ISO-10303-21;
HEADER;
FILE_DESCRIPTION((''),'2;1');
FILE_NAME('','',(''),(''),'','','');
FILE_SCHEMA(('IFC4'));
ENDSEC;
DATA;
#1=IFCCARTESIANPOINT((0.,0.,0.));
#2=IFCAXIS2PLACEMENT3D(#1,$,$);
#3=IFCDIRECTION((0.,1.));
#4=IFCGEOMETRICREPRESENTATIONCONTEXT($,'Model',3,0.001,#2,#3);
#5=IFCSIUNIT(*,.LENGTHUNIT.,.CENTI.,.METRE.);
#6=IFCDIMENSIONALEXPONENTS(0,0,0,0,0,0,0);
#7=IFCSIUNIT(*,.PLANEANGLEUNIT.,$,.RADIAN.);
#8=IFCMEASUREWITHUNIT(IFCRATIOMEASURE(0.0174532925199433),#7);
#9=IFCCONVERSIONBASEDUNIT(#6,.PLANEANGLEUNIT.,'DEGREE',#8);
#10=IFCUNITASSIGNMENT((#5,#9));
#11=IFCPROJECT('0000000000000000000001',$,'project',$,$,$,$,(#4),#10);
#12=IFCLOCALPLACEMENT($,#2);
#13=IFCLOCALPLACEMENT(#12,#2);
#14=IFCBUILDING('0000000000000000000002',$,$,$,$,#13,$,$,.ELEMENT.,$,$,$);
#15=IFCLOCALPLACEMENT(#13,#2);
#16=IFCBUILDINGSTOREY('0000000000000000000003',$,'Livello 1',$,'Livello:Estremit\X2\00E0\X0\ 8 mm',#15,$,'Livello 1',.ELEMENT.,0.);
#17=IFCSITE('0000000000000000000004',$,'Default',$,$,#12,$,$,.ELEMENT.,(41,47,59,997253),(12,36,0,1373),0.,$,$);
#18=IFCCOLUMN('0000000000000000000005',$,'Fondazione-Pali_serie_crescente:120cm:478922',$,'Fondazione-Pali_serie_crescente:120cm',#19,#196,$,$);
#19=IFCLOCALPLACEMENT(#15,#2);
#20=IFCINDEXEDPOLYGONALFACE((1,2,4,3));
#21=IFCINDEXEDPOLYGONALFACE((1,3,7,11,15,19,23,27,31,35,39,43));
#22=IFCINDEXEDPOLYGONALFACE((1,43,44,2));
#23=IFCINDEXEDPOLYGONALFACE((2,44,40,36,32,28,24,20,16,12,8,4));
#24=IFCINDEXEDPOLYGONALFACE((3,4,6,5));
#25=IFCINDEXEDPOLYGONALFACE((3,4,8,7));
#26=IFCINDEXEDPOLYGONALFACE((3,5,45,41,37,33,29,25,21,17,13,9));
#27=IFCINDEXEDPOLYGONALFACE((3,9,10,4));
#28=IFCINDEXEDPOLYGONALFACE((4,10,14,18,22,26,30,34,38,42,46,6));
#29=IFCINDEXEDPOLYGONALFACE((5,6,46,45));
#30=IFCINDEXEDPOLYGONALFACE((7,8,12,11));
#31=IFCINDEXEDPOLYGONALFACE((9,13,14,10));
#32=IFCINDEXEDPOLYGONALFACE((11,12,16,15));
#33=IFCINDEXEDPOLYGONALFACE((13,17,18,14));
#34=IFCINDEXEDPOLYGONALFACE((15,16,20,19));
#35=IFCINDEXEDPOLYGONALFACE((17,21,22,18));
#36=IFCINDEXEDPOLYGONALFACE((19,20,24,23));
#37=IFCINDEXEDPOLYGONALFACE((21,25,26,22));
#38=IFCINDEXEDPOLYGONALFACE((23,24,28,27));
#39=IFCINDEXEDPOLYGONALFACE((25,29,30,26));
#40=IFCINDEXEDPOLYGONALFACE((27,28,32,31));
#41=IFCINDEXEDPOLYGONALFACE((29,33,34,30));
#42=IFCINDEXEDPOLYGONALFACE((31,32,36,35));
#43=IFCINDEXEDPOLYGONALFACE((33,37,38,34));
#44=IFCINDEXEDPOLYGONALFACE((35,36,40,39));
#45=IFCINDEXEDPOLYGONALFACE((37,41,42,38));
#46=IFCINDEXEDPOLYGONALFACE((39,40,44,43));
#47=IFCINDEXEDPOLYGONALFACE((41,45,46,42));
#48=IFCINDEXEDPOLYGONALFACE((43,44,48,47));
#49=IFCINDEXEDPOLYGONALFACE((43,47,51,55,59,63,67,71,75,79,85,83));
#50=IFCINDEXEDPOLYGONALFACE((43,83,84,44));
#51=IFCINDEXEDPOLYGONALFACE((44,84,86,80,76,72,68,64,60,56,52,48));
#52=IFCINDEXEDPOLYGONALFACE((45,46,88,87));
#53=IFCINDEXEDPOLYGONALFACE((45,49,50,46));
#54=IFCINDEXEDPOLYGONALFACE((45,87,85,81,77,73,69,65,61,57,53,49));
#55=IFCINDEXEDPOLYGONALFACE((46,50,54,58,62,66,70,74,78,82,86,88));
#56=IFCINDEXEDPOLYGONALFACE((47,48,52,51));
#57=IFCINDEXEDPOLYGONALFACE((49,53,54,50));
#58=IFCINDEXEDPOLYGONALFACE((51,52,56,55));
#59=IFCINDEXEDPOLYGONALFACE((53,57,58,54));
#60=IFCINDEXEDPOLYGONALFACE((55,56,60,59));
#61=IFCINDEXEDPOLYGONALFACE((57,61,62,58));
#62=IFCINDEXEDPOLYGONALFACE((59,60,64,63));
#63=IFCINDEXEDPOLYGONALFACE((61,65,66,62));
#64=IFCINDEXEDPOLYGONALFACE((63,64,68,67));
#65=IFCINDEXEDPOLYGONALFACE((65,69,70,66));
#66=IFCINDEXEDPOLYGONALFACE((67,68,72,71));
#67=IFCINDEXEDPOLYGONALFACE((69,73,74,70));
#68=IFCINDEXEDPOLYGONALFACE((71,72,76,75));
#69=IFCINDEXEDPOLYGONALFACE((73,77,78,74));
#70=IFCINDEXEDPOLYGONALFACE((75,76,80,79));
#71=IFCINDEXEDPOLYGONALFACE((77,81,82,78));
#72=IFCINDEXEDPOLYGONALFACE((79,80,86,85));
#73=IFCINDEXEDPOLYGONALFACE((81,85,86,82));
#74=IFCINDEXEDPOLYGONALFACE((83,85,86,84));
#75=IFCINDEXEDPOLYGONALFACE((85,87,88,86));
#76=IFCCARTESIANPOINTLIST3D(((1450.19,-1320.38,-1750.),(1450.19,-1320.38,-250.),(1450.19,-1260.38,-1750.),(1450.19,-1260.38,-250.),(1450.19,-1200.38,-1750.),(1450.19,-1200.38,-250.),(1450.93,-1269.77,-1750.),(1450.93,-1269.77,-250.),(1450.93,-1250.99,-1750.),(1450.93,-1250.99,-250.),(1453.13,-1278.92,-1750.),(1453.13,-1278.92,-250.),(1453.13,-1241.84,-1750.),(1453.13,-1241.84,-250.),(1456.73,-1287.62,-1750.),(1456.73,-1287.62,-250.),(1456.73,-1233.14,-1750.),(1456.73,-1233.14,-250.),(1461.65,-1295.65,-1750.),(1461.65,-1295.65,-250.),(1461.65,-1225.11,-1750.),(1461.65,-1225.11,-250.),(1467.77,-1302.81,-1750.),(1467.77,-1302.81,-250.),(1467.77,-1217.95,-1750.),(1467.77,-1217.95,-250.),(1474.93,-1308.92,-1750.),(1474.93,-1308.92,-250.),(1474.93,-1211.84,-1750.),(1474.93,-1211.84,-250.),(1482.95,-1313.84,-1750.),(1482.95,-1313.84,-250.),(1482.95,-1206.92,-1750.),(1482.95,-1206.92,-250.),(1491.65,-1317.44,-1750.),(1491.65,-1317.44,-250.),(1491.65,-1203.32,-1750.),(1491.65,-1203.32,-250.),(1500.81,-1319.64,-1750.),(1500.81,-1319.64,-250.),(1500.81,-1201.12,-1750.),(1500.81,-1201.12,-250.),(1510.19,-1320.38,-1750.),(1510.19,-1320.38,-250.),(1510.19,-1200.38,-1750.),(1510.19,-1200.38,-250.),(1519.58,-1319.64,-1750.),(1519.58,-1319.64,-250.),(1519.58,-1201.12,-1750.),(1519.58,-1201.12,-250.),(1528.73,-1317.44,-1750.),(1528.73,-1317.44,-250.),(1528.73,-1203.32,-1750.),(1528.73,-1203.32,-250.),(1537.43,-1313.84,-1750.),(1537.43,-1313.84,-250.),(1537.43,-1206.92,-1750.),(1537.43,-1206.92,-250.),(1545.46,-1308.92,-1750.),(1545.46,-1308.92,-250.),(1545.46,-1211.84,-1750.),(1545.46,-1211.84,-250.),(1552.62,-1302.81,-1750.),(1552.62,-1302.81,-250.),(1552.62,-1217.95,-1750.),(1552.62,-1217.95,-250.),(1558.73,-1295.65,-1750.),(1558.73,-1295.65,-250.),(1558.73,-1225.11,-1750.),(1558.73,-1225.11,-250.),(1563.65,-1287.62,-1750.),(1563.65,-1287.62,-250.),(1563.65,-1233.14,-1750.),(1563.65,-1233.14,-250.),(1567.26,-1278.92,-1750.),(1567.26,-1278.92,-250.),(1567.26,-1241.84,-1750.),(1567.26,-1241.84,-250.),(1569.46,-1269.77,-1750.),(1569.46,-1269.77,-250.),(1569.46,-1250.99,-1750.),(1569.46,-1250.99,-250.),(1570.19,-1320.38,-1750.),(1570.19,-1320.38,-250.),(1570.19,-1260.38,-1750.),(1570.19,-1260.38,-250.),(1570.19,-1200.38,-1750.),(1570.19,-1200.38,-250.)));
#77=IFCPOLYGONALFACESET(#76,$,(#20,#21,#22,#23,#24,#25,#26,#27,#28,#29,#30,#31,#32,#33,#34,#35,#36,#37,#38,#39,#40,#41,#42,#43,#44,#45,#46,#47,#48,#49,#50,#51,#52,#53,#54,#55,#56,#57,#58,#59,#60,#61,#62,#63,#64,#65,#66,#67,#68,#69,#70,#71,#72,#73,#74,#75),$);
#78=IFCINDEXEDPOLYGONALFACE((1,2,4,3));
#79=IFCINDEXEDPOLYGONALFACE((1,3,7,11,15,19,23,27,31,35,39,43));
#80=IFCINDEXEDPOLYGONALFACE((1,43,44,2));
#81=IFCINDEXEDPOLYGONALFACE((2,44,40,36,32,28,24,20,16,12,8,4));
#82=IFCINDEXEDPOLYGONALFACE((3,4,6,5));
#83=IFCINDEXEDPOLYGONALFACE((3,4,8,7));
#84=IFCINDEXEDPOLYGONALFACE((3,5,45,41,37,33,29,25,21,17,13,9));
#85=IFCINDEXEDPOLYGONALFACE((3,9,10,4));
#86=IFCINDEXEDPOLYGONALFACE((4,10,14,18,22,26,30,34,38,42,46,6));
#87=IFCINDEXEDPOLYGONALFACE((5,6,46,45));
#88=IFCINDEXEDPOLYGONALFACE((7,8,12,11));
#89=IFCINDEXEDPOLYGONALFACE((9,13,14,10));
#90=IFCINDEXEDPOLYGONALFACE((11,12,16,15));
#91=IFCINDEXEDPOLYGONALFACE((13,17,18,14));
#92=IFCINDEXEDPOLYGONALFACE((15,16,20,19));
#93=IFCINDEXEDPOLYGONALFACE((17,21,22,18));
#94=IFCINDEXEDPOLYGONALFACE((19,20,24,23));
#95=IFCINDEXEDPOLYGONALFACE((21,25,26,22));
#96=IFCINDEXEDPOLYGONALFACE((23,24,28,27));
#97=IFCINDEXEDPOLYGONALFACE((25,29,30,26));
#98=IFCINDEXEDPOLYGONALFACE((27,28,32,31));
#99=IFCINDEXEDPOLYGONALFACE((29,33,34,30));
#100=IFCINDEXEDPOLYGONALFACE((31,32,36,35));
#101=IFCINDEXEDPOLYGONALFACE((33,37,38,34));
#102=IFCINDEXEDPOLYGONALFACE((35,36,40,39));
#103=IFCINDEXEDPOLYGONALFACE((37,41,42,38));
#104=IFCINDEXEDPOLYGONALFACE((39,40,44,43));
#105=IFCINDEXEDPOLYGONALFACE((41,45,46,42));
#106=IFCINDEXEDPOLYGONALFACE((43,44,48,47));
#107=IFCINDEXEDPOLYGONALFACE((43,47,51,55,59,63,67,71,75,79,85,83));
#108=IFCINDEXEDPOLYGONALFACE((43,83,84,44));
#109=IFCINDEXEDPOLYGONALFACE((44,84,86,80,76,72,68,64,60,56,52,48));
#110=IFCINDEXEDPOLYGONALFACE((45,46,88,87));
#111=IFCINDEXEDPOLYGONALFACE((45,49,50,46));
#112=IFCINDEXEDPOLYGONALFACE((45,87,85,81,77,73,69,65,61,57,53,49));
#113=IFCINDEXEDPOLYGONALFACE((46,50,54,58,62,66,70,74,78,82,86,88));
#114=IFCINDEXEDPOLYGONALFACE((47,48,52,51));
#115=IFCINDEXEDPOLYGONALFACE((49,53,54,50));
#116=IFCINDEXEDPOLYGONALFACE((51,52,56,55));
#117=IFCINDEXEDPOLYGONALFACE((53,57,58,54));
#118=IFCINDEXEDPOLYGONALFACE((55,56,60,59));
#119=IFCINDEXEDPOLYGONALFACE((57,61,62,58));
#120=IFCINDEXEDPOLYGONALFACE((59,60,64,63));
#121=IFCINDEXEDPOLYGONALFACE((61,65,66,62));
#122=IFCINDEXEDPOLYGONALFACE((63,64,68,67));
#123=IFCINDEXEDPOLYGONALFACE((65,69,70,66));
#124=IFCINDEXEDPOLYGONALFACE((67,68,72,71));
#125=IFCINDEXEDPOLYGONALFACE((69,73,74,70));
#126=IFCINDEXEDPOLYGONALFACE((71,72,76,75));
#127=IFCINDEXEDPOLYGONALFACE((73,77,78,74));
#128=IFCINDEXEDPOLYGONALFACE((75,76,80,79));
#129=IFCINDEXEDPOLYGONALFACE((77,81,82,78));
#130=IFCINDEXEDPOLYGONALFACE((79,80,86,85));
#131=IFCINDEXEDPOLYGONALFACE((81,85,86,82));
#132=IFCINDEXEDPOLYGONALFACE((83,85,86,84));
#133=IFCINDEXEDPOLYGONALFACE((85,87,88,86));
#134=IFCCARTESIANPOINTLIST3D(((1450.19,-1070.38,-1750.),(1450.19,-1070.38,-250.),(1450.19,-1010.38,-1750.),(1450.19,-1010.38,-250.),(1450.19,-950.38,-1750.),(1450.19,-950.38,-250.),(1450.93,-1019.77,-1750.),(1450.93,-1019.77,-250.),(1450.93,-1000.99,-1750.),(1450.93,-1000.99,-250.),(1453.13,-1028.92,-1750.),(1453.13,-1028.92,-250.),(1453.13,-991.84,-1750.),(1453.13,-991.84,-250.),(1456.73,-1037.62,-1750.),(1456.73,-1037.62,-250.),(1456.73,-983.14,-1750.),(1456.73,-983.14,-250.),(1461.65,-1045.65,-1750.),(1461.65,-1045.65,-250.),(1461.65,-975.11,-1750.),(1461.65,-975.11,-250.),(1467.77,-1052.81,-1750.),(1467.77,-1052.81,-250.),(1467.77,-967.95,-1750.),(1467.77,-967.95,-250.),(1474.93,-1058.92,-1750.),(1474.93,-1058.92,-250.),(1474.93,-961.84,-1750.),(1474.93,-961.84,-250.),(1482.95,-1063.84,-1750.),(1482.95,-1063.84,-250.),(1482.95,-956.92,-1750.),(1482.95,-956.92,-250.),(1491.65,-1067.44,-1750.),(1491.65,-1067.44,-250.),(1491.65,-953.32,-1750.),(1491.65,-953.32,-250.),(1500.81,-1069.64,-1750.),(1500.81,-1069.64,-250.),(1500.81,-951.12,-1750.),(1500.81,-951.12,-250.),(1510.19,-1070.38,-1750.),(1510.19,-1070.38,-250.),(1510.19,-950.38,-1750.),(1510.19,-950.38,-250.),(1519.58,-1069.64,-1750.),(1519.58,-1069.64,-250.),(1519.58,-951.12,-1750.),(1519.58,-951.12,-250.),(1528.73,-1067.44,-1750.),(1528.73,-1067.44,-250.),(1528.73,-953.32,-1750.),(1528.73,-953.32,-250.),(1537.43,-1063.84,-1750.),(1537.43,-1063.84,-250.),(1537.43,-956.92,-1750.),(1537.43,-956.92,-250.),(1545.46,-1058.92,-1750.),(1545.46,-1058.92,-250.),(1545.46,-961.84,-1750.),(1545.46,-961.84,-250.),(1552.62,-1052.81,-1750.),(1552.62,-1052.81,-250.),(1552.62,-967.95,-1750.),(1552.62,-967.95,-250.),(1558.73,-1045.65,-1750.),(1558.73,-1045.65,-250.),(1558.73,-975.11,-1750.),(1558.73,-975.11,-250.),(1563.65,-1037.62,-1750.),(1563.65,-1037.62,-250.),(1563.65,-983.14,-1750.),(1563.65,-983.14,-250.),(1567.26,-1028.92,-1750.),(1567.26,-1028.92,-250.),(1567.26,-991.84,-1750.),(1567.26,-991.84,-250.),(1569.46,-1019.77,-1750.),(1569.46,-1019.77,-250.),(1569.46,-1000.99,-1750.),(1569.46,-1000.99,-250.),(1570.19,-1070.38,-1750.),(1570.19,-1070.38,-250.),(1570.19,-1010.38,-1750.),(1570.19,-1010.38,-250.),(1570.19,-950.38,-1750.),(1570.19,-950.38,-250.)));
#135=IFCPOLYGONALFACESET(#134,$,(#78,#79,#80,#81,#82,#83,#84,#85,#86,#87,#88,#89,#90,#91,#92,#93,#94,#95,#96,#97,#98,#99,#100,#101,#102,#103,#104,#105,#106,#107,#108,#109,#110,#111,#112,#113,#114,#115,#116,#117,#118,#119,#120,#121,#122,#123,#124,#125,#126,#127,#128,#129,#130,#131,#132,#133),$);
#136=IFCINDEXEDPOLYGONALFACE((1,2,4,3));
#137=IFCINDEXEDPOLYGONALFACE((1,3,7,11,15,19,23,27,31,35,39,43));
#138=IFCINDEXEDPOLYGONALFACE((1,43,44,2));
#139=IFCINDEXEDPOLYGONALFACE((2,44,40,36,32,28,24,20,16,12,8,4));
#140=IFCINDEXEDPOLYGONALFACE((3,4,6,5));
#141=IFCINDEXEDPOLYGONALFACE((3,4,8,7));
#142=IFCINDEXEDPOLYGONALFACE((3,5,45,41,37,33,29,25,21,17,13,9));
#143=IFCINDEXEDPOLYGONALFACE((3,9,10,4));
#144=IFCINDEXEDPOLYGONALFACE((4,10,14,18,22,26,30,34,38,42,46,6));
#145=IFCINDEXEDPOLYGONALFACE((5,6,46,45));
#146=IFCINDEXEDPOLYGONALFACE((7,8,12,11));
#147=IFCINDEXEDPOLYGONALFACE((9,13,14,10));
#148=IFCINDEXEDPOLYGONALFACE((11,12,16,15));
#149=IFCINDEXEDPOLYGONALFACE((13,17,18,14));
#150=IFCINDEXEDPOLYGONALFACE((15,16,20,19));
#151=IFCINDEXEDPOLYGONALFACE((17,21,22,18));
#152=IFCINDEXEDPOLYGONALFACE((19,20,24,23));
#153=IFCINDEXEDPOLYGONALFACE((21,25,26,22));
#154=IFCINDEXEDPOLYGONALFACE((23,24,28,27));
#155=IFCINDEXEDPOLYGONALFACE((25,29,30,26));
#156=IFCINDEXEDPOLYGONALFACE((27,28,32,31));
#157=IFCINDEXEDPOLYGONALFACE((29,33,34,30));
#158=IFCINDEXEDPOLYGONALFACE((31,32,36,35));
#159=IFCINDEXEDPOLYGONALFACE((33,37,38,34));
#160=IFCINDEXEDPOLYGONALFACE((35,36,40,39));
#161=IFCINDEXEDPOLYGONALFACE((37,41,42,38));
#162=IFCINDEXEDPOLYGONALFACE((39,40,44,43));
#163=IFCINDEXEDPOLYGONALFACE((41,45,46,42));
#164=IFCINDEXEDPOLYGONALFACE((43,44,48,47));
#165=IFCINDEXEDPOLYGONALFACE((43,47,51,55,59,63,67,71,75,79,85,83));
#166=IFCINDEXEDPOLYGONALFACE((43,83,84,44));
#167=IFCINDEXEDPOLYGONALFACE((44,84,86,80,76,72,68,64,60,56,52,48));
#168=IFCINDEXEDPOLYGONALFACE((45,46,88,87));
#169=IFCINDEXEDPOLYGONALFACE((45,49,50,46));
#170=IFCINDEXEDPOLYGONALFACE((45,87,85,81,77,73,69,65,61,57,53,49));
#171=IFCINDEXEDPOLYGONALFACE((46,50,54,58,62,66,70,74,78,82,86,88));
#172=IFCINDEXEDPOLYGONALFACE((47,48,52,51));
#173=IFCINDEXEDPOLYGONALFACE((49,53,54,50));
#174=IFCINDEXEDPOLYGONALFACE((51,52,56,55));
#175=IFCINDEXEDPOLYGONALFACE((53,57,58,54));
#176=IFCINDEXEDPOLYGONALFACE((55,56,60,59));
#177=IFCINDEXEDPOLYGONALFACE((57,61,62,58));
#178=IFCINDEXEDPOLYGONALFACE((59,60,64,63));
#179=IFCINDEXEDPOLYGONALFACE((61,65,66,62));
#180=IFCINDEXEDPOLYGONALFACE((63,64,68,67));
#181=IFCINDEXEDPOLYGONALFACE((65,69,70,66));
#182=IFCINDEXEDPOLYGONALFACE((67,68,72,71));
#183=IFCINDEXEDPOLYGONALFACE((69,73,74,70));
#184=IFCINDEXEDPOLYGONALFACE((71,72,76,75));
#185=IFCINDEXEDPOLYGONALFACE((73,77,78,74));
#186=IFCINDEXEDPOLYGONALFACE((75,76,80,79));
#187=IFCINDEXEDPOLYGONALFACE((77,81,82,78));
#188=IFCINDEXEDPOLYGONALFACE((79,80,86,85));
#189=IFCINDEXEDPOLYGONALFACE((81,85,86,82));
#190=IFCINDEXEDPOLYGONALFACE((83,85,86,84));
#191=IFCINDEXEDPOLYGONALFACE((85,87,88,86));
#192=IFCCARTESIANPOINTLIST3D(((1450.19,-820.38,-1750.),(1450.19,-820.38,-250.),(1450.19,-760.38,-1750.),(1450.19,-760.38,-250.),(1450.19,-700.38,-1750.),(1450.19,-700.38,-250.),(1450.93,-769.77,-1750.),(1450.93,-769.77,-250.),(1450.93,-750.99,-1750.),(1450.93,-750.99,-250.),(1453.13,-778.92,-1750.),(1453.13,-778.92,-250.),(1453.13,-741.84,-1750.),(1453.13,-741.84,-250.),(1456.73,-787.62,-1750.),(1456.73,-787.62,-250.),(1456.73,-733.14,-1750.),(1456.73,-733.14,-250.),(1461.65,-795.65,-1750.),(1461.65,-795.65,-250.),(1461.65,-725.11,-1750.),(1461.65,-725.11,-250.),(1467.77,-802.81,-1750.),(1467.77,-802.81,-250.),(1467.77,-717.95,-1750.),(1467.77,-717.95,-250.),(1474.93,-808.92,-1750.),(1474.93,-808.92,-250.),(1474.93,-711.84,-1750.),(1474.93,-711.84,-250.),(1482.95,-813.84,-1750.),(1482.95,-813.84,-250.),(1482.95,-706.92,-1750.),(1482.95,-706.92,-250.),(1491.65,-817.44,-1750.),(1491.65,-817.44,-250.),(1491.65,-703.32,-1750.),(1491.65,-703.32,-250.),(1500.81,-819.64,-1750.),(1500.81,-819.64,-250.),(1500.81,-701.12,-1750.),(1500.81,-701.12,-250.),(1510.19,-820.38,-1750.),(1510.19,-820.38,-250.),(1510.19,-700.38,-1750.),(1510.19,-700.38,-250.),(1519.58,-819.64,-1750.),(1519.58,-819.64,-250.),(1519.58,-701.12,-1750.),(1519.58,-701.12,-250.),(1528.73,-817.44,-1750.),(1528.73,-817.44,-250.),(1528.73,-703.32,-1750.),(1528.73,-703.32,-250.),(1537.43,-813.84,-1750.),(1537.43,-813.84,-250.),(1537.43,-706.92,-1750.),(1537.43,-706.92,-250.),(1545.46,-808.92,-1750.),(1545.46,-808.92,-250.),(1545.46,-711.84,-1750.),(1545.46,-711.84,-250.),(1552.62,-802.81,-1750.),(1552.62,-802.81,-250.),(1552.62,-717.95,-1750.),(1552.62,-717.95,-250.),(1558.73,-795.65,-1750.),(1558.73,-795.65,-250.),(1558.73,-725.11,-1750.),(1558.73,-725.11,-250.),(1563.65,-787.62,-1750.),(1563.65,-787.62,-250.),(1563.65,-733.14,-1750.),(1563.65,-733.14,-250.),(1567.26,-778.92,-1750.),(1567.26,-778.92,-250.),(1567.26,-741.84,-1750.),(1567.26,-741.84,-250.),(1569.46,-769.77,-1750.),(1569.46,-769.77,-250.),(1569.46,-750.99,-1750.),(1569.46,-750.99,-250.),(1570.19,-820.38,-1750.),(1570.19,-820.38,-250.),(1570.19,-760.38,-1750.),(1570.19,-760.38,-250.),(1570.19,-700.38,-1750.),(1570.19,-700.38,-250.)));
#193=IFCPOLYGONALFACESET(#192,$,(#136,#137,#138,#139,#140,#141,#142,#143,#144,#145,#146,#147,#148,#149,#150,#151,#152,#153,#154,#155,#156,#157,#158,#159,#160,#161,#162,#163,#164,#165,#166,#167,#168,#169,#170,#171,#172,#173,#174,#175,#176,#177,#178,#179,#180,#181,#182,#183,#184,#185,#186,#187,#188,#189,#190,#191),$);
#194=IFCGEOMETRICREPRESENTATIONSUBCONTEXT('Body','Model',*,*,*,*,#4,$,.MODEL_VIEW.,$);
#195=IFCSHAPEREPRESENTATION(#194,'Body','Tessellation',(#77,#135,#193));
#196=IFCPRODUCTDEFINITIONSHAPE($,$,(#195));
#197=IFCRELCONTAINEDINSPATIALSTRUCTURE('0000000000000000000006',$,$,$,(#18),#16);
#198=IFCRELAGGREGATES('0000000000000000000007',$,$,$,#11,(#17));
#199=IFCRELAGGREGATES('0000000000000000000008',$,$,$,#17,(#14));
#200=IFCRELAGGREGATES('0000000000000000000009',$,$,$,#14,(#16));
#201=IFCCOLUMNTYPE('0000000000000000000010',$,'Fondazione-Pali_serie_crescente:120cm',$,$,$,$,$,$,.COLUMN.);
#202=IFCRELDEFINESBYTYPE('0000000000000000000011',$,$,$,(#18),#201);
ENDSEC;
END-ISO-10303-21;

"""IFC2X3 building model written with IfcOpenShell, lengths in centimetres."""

from ifc_helpers import new_model, entity, si_unit, converted_unit, direction, frame, frame_2d, origin, origin_2d_with_axis, place, context, subcontext, project, spatial, rectangle, circle, extrude, boolean, source, transform, mapped, type_object, type_shapes, element, save


model = new_model("IFC2X3")

# Units and contexts
model_context = context("Model", 3, precision=0.001, world=origin(), true_north=direction((0.0, 1.0)))
body_context = subcontext(model_context, "Body", "Model", "MODEL_VIEW")
ifc_project = project(units=[si_unit("LENGTHUNIT", "METRE", prefix="CENTI"), converted_unit("PLANEANGLEUNIT", "DEGREE", entity("IfcRatioMeasure", 0.0174532925199433), si_unit("PLANEANGLEUNIT", "RADIAN"), dimensions=[0, 0, 0, 0, 0, 0, 0])], contexts=[model_context])

# Site, building, storey
site_placement = place(None, origin())
site = spatial("IfcSite", under=ifc_project, at=site_placement, Name="Default", CompositionType="ELEMENT", RefLatitude=(41, 47, 59, 997253), RefLongitude=(12, 36, 0, 1373), RefElevation=0.0)
building_placement = place(site_placement, origin())
building = spatial("IfcBuilding", under=site, at=building_placement, CompositionType="ELEMENT")
storey_placement = place(building_placement, origin())
storey = spatial("IfcBuildingStorey", under=building, at=storey_placement, Name="Livello 1", ObjectType="Livello:Estremità 8 mm", LongName="Livello 1", CompositionType="ELEMENT", Elevation=0.0)

# Column
column_type_1 = type_object("IfcColumnType", Name="Fondazione-Pali_serie_crescente:120cm", PredefinedType="COLUMN")
shared_shape_1 = source(origin(), body_context, "Body", "SweptSolid", [
    boolean("DIFFERENCE", extrude(rectangle(XDim=1500.0, YDim=120.0, at=origin_2d_with_axis()), frame((710.0, 0.0, -750.0), z_axis=(1.0, 0.0, 0.0), x_axis=(0.0, 0.0, -1.0)), (0.0, 0.0, 1.0), 120.0), extrude(circle(Radius=60.0, at=frame_2d((0.0, 0.0), x_axis=(1.0, 0.0))), frame((770.0, 0.0, -1500.0), z_axis=(0.0, 0.0, -1.0), x_axis=(1.0, 0.0, 0.0)), (0.0, 0.0, -1.0), 1500.0)),
    boolean("DIFFERENCE", extrude(rectangle(XDim=1500.0, YDim=120.0, at=origin_2d_with_axis()), frame((460.0, 0.0, -750.0), z_axis=(1.0, 0.0, 0.0), x_axis=(0.0, 0.0, -1.0)), (0.0, 0.0, 1.0), 120.0), extrude(circle(Radius=60.0, at=frame_2d((0.0, 0.0), x_axis=(1.0, 0.0))), frame((520.0, 0.0, -1500.0), z_axis=(0.0, 0.0, -1.0), x_axis=(1.0, 0.0, 0.0)), (0.0, 0.0, -1.0), 1500.0)),
    boolean("DIFFERENCE", extrude(rectangle(XDim=1500.0, YDim=120.0, at=origin_2d_with_axis()), frame((210.0, 0.0, -750.0), z_axis=(1.0, 0.0, 0.0), x_axis=(0.0, 0.0, -1.0)), (0.0, 0.0, 1.0), 120.0), extrude(circle(Radius=60.0, at=frame_2d((0.0, 0.0), x_axis=(1.0, 0.0))), frame((270.0, 0.0, -1500.0), z_axis=(0.0, 0.0, -1.0), x_axis=(1.0, 0.0, 0.0)), (0.0, 0.0, -1.0), 1500.0)),
])
type_shapes(column_type_1, [shared_shape_1])
for number, where, z_axis, x_axis, name in (
    (1, (1510.19, -490.38, -250.0), (0.0, 0.0, 1.0), (0.0, -1.0, 0.0), "Fondazione-Pali_serie_crescente:120cm:478922"),
):
    element("IfcColumn", number, at=place(storey_placement, frame(where, z_axis=z_axis, x_axis=x_axis)), inside=storey, type_object=column_type_1, Name=name, ObjectType="Fondazione-Pali_serie_crescente:120cm", context=body_context, shape_type="MappedRepresentation", body=[
        mapped(shared_shape_1, transform((0.0, 0.0, 0.0), scale=1.0)),
    ])

save(model, "model.ifc")
